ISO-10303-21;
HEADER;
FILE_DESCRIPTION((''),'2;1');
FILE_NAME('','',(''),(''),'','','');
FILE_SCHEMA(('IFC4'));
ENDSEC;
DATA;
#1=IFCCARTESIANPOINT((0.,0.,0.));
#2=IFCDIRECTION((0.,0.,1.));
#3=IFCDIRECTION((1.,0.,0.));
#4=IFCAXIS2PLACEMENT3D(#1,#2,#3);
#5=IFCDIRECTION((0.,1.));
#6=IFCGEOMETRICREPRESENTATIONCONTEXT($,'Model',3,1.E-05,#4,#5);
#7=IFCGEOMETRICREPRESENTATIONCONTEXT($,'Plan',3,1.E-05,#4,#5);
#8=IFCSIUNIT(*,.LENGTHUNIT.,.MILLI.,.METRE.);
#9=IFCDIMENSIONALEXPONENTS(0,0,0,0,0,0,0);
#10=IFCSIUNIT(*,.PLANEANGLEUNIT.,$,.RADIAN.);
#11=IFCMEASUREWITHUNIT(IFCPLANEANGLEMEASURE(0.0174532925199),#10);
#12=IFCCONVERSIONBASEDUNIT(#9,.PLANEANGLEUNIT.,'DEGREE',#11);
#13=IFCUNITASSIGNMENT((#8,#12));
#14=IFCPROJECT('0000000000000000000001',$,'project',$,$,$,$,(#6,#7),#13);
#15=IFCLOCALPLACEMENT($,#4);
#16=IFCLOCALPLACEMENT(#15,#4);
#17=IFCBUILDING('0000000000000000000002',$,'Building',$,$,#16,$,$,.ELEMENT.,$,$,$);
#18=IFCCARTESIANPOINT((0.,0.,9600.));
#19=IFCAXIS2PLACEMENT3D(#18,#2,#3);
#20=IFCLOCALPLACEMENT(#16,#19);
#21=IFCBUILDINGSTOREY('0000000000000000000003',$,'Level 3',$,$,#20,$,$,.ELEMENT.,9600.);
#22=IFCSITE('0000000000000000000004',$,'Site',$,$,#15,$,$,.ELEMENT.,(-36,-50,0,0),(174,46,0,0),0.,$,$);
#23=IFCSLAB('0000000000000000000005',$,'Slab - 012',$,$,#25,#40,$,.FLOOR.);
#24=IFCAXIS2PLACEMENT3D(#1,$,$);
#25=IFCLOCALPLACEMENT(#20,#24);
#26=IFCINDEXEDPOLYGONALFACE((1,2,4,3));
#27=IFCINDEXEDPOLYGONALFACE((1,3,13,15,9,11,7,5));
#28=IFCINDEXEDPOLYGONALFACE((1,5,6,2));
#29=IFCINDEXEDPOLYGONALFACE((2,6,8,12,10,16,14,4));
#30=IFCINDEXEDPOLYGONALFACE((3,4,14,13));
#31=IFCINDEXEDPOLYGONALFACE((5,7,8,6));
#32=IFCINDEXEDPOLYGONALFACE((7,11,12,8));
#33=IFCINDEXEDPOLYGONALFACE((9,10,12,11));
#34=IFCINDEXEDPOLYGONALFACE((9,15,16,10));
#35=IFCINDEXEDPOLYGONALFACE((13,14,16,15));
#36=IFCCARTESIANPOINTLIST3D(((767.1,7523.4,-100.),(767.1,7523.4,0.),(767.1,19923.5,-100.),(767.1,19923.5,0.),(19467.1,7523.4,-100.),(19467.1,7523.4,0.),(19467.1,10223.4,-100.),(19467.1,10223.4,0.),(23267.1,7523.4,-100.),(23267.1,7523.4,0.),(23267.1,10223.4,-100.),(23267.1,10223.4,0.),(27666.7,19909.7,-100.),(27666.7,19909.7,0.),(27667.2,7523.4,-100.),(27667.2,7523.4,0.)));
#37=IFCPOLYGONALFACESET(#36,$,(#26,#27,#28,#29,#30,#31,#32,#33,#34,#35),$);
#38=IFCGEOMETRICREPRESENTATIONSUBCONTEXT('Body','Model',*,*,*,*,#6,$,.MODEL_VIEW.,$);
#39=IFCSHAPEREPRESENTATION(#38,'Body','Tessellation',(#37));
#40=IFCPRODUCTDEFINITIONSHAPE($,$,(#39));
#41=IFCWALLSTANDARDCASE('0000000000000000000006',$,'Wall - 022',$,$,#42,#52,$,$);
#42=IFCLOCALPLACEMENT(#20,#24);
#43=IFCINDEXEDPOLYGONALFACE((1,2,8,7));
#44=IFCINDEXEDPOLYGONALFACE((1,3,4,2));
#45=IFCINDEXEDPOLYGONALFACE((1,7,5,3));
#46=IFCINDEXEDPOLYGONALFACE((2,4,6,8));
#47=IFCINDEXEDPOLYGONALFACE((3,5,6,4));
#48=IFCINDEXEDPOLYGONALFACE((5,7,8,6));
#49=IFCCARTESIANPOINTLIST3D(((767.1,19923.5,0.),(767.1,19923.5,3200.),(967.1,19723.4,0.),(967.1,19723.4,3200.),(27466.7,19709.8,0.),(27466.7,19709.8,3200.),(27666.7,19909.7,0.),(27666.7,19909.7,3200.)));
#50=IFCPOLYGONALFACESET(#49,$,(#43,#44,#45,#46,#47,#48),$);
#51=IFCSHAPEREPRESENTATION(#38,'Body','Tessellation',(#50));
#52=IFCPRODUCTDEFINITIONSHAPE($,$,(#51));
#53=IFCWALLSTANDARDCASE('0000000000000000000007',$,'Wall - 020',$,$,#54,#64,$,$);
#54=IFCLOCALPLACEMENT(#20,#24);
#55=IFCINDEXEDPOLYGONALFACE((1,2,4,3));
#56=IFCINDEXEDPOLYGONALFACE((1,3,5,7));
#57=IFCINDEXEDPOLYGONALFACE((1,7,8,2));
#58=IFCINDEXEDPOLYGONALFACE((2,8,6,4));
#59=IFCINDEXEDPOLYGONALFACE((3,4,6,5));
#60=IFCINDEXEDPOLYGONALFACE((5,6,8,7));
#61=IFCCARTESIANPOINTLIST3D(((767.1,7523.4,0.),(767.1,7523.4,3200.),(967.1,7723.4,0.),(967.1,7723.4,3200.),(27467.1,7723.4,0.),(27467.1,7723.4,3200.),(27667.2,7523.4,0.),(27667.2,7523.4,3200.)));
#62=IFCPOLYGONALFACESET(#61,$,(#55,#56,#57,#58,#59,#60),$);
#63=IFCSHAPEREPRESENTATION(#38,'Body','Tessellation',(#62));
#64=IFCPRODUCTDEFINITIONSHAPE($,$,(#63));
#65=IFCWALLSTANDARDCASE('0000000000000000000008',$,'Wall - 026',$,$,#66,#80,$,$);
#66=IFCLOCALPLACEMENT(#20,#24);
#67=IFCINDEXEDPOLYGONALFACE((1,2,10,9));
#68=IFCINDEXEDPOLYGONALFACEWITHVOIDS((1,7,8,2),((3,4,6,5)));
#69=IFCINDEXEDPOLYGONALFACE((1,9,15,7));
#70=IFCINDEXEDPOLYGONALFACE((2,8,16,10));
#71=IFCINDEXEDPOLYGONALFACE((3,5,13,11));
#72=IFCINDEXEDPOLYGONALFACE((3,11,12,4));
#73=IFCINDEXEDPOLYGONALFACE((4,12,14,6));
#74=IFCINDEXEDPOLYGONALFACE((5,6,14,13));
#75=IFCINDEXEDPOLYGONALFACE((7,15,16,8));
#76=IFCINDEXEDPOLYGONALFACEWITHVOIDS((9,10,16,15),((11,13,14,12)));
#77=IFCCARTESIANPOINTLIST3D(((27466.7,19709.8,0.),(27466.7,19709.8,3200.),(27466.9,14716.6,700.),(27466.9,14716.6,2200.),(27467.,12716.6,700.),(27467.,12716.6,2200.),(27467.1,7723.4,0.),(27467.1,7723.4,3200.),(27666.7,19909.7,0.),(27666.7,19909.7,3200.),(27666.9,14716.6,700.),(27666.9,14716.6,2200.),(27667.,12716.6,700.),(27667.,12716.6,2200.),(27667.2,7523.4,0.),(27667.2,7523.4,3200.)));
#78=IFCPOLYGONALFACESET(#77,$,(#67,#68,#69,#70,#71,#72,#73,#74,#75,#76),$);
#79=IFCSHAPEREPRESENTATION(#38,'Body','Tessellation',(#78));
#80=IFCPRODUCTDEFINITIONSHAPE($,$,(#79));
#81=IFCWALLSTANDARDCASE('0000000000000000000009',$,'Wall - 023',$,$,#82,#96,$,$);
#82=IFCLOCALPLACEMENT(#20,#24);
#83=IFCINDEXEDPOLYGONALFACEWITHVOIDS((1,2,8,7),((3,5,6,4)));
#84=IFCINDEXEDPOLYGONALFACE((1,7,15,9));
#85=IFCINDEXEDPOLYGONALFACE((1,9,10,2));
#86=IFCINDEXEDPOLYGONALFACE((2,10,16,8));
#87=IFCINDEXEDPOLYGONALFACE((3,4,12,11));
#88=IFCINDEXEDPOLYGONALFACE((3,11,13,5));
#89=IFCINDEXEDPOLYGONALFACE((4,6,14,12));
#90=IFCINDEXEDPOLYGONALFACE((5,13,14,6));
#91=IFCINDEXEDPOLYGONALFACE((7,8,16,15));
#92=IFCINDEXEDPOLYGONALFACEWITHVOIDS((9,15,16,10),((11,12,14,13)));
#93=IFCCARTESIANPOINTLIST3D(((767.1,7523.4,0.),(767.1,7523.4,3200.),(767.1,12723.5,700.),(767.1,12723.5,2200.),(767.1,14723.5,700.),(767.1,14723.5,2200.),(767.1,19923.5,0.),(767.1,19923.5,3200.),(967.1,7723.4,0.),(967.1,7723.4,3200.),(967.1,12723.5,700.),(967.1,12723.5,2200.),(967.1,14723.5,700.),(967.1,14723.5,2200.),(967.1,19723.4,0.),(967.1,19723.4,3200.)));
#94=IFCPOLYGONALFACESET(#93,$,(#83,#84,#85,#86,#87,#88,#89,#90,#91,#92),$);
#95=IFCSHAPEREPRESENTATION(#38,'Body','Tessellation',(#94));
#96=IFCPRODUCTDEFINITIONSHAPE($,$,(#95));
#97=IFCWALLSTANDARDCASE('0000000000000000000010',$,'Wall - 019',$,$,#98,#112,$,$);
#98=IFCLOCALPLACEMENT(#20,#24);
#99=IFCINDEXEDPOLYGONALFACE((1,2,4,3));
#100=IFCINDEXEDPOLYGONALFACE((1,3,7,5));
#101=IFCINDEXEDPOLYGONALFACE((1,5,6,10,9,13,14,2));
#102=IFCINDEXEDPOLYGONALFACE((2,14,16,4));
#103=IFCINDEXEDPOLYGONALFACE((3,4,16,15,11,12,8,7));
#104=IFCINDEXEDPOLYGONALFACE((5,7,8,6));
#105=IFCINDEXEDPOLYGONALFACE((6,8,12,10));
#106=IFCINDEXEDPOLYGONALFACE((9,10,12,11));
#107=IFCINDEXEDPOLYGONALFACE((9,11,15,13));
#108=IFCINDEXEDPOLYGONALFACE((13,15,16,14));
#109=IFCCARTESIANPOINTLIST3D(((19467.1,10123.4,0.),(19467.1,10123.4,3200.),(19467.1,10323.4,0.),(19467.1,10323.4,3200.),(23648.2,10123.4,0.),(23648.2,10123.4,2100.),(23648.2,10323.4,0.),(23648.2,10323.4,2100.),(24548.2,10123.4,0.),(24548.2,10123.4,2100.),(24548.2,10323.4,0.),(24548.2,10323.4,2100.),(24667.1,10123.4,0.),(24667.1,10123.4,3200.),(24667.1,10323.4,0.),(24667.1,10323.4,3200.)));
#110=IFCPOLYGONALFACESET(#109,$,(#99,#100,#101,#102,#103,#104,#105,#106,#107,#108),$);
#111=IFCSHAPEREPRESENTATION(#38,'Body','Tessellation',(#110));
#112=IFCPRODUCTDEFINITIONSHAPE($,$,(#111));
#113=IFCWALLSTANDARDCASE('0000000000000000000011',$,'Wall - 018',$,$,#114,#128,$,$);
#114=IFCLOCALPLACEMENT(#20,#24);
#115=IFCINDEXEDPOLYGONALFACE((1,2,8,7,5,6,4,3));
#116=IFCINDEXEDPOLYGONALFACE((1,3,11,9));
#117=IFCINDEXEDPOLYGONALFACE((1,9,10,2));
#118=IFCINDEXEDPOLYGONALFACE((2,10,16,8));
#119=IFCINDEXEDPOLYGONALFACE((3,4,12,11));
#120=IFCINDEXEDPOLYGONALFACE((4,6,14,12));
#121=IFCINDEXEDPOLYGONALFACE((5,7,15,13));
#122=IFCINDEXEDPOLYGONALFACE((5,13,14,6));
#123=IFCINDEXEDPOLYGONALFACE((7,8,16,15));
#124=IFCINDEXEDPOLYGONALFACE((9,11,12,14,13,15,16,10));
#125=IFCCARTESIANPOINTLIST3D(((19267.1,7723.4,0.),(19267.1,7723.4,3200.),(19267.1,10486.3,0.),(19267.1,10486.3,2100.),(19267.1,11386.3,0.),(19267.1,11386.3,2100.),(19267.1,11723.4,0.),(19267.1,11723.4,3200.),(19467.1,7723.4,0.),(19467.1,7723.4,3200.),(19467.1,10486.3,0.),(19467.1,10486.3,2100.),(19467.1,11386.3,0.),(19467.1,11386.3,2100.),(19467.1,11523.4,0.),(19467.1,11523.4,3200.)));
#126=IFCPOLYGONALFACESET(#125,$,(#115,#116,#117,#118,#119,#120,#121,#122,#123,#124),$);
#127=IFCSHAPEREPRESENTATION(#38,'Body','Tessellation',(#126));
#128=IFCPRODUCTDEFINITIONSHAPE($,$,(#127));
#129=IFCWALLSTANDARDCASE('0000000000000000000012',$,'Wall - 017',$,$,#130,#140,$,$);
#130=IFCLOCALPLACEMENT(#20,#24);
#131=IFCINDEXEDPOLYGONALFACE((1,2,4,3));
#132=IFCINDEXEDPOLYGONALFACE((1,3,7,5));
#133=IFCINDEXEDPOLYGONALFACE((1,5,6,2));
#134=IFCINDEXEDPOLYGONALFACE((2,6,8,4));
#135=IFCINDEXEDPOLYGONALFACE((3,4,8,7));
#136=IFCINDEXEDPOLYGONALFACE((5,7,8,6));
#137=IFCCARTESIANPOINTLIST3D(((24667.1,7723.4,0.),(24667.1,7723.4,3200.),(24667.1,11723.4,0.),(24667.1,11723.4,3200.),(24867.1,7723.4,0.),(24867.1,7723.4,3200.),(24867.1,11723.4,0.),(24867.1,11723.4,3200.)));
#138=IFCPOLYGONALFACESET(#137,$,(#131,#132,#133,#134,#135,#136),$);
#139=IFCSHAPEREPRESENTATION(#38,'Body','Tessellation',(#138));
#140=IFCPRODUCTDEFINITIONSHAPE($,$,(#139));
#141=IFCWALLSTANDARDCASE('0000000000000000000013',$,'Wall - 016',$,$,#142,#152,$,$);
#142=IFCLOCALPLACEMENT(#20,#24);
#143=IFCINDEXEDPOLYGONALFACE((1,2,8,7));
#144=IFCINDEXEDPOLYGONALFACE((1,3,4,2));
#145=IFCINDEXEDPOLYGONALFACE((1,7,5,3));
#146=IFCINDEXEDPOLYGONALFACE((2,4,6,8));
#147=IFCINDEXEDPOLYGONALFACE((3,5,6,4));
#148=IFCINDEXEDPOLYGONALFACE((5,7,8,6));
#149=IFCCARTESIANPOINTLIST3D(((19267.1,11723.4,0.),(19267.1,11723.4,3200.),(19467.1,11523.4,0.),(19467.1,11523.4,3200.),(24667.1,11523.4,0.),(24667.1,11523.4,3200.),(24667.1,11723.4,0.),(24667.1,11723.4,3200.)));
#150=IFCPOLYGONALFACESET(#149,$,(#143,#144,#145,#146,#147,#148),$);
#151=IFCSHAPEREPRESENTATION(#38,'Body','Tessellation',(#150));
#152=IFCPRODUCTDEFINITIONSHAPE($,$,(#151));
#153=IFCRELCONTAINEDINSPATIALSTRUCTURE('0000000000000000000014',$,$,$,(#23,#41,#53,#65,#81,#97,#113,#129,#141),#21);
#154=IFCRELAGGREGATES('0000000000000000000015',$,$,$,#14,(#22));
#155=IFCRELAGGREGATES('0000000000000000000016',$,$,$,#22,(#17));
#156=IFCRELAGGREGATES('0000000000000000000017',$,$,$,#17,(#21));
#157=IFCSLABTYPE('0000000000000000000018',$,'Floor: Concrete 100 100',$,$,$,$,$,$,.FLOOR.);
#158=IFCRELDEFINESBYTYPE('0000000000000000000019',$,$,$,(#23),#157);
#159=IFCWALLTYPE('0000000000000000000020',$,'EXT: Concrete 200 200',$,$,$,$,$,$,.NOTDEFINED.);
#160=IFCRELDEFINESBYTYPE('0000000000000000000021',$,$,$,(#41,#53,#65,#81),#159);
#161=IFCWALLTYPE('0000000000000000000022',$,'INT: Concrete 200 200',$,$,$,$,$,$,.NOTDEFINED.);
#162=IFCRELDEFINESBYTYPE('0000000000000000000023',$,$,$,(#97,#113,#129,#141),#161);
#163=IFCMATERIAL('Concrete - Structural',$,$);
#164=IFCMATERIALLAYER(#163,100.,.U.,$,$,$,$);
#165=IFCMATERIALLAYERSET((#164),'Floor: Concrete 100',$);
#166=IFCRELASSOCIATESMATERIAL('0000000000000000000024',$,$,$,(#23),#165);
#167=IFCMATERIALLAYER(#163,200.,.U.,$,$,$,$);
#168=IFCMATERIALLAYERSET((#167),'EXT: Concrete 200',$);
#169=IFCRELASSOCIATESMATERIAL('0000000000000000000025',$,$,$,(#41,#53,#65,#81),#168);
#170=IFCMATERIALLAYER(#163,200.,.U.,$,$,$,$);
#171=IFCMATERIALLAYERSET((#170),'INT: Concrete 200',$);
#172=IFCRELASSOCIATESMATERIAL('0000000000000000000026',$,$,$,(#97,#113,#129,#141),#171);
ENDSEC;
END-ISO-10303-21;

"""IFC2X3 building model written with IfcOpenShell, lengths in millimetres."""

from ifc_helpers import new_model, entity, si_unit, converted_unit, direction, frame, origin_with_axes, origin_2d_with_axis, place, context, subcontext, project, spatial, polyline, rectangle, outline, extrude, material, layer, layer_set, layer_usage, type_object, element, save


model = new_model("IFC2X3")

# Units and contexts
model_context = context("Model", 3, precision=1e-05, world=origin_with_axes(), true_north=direction((0.0, 1.0)))
plan_context = context("Plan", 3, precision=1e-05, world=origin_with_axes(), true_north=direction((0.0, 1.0)))
body_context = subcontext(model_context, "Body", "Model", "MODEL_VIEW")
ifc_project = project(units=[si_unit("LENGTHUNIT", "METRE", prefix="MILLI"), converted_unit("PLANEANGLEUNIT", "DEGREE", entity("IfcPlaneAngleMeasure", 0.0174532925199), si_unit("PLANEANGLEUNIT", "RADIAN"), dimensions=[0, 0, 0, 0, 0, 0, 0])], contexts=[model_context, plan_context])

# Site, building, storey
site_placement = place(None, origin_with_axes())
site = spatial("IfcSite", under=ifc_project, at=site_placement, Name="Site", CompositionType="ELEMENT", RefLatitude=(-36, -50, 0, 0), RefLongitude=(174, 46, 0, 0), RefElevation=0.0)
building_placement = place(site_placement, origin_with_axes())
building = spatial("IfcBuilding", under=site, at=building_placement, Name="Building", CompositionType="ELEMENT")
storey_placement = place(building_placement, frame((0.0, 0.0, 9600.0), z_axis=(0.0, 0.0, 1.0), x_axis=(1.0, 0.0, 0.0)))
storey = spatial("IfcBuildingStorey", under=building, at=storey_placement, Name="Level 3", CompositionType="ELEMENT", Elevation=9600.0)

# Slab
ifc_material = material(Name="Concrete - Structural")
ifc_layer_1 = layer(ifc_material, 100.0, ventilated="UNKNOWN")
ifc_layer_set_1 = layer_set([ifc_layer_1], Name="Floor: Concrete 100")
ifc_layer_usage_1 = layer_usage(ifc_layer_set_1, "AXIS3", "NEGATIVE", 100.0)
slab_type = type_object("IfcSlabType", Name="Floor: Concrete 100 100", PredefinedType="FLOOR")
slab_placement = place(storey_placement, frame((767.1, 19923.5, 0.0), z_axis=(0.0, 0.0, 1.0), x_axis=(1.0, 0.0, 0.0)))
element("IfcSlab", 1, at=slab_placement, inside=storey, type_object=slab_type, material=ifc_layer_usage_1, Name="Slab - 012", PredefinedType="FLOOR", context=body_context, shape_type="SweptSolid", body=[
    extrude(outline(polyline([(0.0, 0.0), (0.0, -12400.1), (18700.0, -12400.1), (18700.0, -9700.1), (22500.0, -9700.1), (22500.0, -12400.1), (26900.0, -12400.1), (26899.5, -13.8), (0.0, 0.0)])), frame((0.0, 0.0, -100.0), z_axis=(0.0, 0.0, 1.0), x_axis=(1.0, 0.0, 0.0)), (0.0, 0.0, 1.0), 100.0),
])

# Walls
ifc_layer_2 = layer(ifc_material, 200.0, ventilated="UNKNOWN")
ifc_layer_set_2 = layer_set([ifc_layer_2], Name="EXT: Concrete 200")
ifc_layer_usage_2 = layer_usage(ifc_layer_set_2, "AXIS2", "POSITIVE", 0.0)
wall_type_1 = type_object("IfcWallType", Name="EXT: Concrete 200 200", PredefinedType="NOTDEFINED")
wall_1_placement = place(storey_placement, frame((967.1, 19723.4, 0.0), z_axis=(0.0, 0.0, 1.0), x_axis=(1.0, -0.000513, 0.0)))
element("IfcWallStandardCase", 2, at=wall_1_placement, inside=storey, type_object=wall_type_1, material=ifc_layer_usage_2, Name="Wall - 022", context=body_context, shape_type="SweptSolid", body=[
    extrude(outline(polyline([(0.0, 0.0), (26499.5, 0.0), (26699.4, 200.0), (-200.1, 200.0), (0.0, 0.0)])), origin_with_axes(), (0.0, 0.0, 1.0), 3200.0),
])
ifc_layer_usage_3 = layer_usage(ifc_layer_set_2, "AXIS2", "POSITIVE", 0.0)
wall_2_placement = place(storey_placement, frame((27667.1, 7723.4, 0.0), z_axis=(0.0, 0.0, 1.0), x_axis=(-1.0, 0.0, 0.0)))
element("IfcWallStandardCase", 3, at=wall_2_placement, inside=storey, type_object=wall_type_1, material=ifc_layer_usage_3, Name="Wall - 020", context=body_context, shape_type="SweptSolid", body=[
    extrude(outline(polyline([(200.0, 0.0), (26700.0, 0.0), (26900.0, 200.0), (0.0, 200.0), (200.0, 0.0)])), origin_with_axes(), (0.0, 0.0, 1.0), 3200.0),
])

# Walls, openings
ifc_layer_usage_4 = layer_usage(ifc_layer_set_2, "AXIS2", "POSITIVE", -200.0)
wall_3_placement = place(storey_placement, frame((27666.7, 19709.7, 0.0), z_axis=(0.0, 0.0, 1.0), x_axis=(0.000039, -1.0, 0.0)))
wall_3 = element("IfcWallStandardCase", 4, at=wall_3_placement, inside=storey, type_object=wall_type_1, material=ifc_layer_usage_4, Name="Wall - 026", context=body_context, shape_type="SweptSolid", body=[
    extrude(outline(polyline([(-0.1, -200.0), (11986.3, -200.0), (12186.3, 0.0), (-200.0, 0.0), (-0.1, -200.0)])), origin_with_axes(), (0.0, 0.0, 1.0), 3200.0),
])
opening_1_placement = place(wall_3_placement, frame((5993.2, 0.0, 700.0), z_axis=(0.0, 0.0, 1.0), x_axis=(1.0, 0.0, 0.0)))
element("IfcOpeningElement", 5, at=opening_1_placement, cuts=wall_3, context=body_context, shape_type="SweptSolid", body=[
    extrude(rectangle(XDim=2000.0, YDim=1500.0, at=origin_2d_with_axis()), frame((0.0, -200.0, 750.0), z_axis=(0.0, 1.0, 0.0), x_axis=(1.0, 0.0, 0.0)), (0.0, 0.0, 1.0), 600.0),
])
ifc_layer_usage_5 = layer_usage(ifc_layer_set_2, "AXIS2", "POSITIVE", -200.0)
wall_4_placement = place(storey_placement, frame((967.1, 19723.4, 0.0), z_axis=(0.0, 0.0, 1.0), x_axis=(0.0, -1.0, 0.0)))
wall_4 = element("IfcWallStandardCase", 6, at=wall_4_placement, inside=storey, type_object=wall_type_1, material=ifc_layer_usage_5, Name="Wall - 023", context=body_context, shape_type="SweptSolid", body=[
    extrude(outline(polyline([(-200.1, -200.0), (12200.0, -200.0), (12000.0, 0.0), (0.0, 0.0), (-200.1, -200.0)])), origin_with_axes(), (0.0, 0.0, 1.0), 3200.0),
])
opening_2_placement = place(wall_4_placement, frame((5999.9, 0.0, 700.0), z_axis=(0.0, 0.0, 1.0), x_axis=(1.0, 0.0, 0.0)))
element("IfcOpeningElement", 7, at=opening_2_placement, cuts=wall_4, context=body_context, shape_type="SweptSolid", body=[
    extrude(rectangle(XDim=2000.0, YDim=1500.0, at=origin_2d_with_axis()), frame((0.0, 200.0, 750.0), z_axis=(0.0, -1.0, 0.0), x_axis=(-1.0, 0.0, 0.0)), (0.0, 0.0, 1.0), 600.0),
])
ifc_layer_3 = layer(ifc_material, 200.0, ventilated="UNKNOWN")
ifc_layer_set_3 = layer_set([ifc_layer_3], Name="INT: Concrete 200")
ifc_layer_usage_6 = layer_usage(ifc_layer_set_3, "AXIS2", "POSITIVE", -200.0)
wall_type_2 = type_object("IfcWallType", Name="INT: Concrete 200 200", PredefinedType="NOTDEFINED")
wall_5_placement = place(storey_placement, frame((19467.1, 10323.4, 0.0), z_axis=(0.0, 0.0, 1.0), x_axis=(1.0, 0.0, 0.0)))
wall_5 = element("IfcWallStandardCase", 8, at=wall_5_placement, inside=storey, type_object=wall_type_2, material=ifc_layer_usage_6, Name="Wall - 019", context=body_context, shape_type="SweptSolid", body=[
    extrude(outline(polyline([(0.0, -200.0), (5200.0, -200.0), (5200.0, 0.0), (0.0, 0.0), (0.0, -200.0)])), origin_with_axes(), (0.0, 0.0, 1.0), 3200.0),
])
opening_3_placement = place(wall_5_placement, frame((4631.0, 0.0, 0.0), z_axis=(0.0, 0.0, 1.0), x_axis=(1.0, 0.0, 0.0)))
element("IfcOpeningElement", 9, at=opening_3_placement, cuts=wall_5, context=body_context, shape_type="SweptSolid", body=[
    extrude(rectangle(XDim=900.0, YDim=2100.0, at=origin_2d_with_axis()), frame((0.0, 200.0, 1050.0), z_axis=(0.0, 1.0, 0.0), x_axis=(1.0, 0.0, 0.0)), (0.0, 0.0, -1.0), 600.0),
])
ifc_layer_usage_7 = layer_usage(ifc_layer_set_3, "AXIS2", "POSITIVE", -200.0)
wall_6_placement = place(storey_placement, frame((19467.1, 11523.4, 0.0), z_axis=(0.0, 0.0, 1.0), x_axis=(0.0, -1.0, 0.0)))
wall_6 = element("IfcWallStandardCase", 10, at=wall_6_placement, inside=storey, type_object=wall_type_2, material=ifc_layer_usage_7, Name="Wall - 018", context=body_context, shape_type="SweptSolid", body=[
    extrude(outline(polyline([(-200.0, -200.0), (3800.0, -200.0), (3800.0, 0.0), (0.0, 0.0), (-200.0, -200.0)])), origin_with_axes(), (0.0, 0.0, 1.0), 3200.0),
])
opening_4_placement = place(wall_6_placement, frame((587.1, 0.0, 0.0), z_axis=(0.0, 0.0, 1.0), x_axis=(1.0, 0.0, 0.0)))
element("IfcOpeningElement", 11, at=opening_4_placement, cuts=wall_6, context=body_context, shape_type="SweptSolid", body=[
    extrude(rectangle(XDim=900.0, YDim=2100.0, at=origin_2d_with_axis()), frame((0.0, -200.0, 1050.0), z_axis=(0.0, 1.0, 0.0), x_axis=(1.0, 0.0, 0.0)), (0.0, 0.0, 1.0), 600.0),
])

# Walls
ifc_layer_usage_8 = layer_usage(ifc_layer_set_3, "AXIS2", "POSITIVE", 0.0)
wall_7_placement = place(storey_placement, frame((24667.1, 11723.4, 0.0), z_axis=(0.0, 0.0, 1.0), x_axis=(0.0, -1.0, 0.0)))
element("IfcWallStandardCase", 12, at=wall_7_placement, inside=storey, type_object=wall_type_2, material=ifc_layer_usage_8, Name="Wall - 017", context=body_context, shape_type="SweptSolid", body=[
    extrude(outline(polyline([(0.0, 0.0), (4000.0, 0.0), (4000.0, 200.0), (0.0, 200.0), (0.0, 0.0)])), origin_with_axes(), (0.0, 0.0, 1.0), 3200.0),
])
ifc_layer_usage_9 = layer_usage(ifc_layer_set_3, "AXIS2", "POSITIVE", 0.0)
wall_8_placement = place(storey_placement, frame((19467.1, 11523.4, 0.0), z_axis=(0.0, 0.0, 1.0), x_axis=(1.0, 0.0, 0.0)))
element("IfcWallStandardCase", 13, at=wall_8_placement, inside=storey, type_object=wall_type_2, material=ifc_layer_usage_9, Name="Wall - 016", context=body_context, shape_type="SweptSolid", body=[
    extrude(outline(polyline([(0.0, 0.0), (5200.0, 0.0), (5200.0, 200.0), (-200.0, 200.0), (0.0, 0.0)])), origin_with_axes(), (0.0, 0.0, 1.0), 3200.0),
])

save(model, "model.ifc")
